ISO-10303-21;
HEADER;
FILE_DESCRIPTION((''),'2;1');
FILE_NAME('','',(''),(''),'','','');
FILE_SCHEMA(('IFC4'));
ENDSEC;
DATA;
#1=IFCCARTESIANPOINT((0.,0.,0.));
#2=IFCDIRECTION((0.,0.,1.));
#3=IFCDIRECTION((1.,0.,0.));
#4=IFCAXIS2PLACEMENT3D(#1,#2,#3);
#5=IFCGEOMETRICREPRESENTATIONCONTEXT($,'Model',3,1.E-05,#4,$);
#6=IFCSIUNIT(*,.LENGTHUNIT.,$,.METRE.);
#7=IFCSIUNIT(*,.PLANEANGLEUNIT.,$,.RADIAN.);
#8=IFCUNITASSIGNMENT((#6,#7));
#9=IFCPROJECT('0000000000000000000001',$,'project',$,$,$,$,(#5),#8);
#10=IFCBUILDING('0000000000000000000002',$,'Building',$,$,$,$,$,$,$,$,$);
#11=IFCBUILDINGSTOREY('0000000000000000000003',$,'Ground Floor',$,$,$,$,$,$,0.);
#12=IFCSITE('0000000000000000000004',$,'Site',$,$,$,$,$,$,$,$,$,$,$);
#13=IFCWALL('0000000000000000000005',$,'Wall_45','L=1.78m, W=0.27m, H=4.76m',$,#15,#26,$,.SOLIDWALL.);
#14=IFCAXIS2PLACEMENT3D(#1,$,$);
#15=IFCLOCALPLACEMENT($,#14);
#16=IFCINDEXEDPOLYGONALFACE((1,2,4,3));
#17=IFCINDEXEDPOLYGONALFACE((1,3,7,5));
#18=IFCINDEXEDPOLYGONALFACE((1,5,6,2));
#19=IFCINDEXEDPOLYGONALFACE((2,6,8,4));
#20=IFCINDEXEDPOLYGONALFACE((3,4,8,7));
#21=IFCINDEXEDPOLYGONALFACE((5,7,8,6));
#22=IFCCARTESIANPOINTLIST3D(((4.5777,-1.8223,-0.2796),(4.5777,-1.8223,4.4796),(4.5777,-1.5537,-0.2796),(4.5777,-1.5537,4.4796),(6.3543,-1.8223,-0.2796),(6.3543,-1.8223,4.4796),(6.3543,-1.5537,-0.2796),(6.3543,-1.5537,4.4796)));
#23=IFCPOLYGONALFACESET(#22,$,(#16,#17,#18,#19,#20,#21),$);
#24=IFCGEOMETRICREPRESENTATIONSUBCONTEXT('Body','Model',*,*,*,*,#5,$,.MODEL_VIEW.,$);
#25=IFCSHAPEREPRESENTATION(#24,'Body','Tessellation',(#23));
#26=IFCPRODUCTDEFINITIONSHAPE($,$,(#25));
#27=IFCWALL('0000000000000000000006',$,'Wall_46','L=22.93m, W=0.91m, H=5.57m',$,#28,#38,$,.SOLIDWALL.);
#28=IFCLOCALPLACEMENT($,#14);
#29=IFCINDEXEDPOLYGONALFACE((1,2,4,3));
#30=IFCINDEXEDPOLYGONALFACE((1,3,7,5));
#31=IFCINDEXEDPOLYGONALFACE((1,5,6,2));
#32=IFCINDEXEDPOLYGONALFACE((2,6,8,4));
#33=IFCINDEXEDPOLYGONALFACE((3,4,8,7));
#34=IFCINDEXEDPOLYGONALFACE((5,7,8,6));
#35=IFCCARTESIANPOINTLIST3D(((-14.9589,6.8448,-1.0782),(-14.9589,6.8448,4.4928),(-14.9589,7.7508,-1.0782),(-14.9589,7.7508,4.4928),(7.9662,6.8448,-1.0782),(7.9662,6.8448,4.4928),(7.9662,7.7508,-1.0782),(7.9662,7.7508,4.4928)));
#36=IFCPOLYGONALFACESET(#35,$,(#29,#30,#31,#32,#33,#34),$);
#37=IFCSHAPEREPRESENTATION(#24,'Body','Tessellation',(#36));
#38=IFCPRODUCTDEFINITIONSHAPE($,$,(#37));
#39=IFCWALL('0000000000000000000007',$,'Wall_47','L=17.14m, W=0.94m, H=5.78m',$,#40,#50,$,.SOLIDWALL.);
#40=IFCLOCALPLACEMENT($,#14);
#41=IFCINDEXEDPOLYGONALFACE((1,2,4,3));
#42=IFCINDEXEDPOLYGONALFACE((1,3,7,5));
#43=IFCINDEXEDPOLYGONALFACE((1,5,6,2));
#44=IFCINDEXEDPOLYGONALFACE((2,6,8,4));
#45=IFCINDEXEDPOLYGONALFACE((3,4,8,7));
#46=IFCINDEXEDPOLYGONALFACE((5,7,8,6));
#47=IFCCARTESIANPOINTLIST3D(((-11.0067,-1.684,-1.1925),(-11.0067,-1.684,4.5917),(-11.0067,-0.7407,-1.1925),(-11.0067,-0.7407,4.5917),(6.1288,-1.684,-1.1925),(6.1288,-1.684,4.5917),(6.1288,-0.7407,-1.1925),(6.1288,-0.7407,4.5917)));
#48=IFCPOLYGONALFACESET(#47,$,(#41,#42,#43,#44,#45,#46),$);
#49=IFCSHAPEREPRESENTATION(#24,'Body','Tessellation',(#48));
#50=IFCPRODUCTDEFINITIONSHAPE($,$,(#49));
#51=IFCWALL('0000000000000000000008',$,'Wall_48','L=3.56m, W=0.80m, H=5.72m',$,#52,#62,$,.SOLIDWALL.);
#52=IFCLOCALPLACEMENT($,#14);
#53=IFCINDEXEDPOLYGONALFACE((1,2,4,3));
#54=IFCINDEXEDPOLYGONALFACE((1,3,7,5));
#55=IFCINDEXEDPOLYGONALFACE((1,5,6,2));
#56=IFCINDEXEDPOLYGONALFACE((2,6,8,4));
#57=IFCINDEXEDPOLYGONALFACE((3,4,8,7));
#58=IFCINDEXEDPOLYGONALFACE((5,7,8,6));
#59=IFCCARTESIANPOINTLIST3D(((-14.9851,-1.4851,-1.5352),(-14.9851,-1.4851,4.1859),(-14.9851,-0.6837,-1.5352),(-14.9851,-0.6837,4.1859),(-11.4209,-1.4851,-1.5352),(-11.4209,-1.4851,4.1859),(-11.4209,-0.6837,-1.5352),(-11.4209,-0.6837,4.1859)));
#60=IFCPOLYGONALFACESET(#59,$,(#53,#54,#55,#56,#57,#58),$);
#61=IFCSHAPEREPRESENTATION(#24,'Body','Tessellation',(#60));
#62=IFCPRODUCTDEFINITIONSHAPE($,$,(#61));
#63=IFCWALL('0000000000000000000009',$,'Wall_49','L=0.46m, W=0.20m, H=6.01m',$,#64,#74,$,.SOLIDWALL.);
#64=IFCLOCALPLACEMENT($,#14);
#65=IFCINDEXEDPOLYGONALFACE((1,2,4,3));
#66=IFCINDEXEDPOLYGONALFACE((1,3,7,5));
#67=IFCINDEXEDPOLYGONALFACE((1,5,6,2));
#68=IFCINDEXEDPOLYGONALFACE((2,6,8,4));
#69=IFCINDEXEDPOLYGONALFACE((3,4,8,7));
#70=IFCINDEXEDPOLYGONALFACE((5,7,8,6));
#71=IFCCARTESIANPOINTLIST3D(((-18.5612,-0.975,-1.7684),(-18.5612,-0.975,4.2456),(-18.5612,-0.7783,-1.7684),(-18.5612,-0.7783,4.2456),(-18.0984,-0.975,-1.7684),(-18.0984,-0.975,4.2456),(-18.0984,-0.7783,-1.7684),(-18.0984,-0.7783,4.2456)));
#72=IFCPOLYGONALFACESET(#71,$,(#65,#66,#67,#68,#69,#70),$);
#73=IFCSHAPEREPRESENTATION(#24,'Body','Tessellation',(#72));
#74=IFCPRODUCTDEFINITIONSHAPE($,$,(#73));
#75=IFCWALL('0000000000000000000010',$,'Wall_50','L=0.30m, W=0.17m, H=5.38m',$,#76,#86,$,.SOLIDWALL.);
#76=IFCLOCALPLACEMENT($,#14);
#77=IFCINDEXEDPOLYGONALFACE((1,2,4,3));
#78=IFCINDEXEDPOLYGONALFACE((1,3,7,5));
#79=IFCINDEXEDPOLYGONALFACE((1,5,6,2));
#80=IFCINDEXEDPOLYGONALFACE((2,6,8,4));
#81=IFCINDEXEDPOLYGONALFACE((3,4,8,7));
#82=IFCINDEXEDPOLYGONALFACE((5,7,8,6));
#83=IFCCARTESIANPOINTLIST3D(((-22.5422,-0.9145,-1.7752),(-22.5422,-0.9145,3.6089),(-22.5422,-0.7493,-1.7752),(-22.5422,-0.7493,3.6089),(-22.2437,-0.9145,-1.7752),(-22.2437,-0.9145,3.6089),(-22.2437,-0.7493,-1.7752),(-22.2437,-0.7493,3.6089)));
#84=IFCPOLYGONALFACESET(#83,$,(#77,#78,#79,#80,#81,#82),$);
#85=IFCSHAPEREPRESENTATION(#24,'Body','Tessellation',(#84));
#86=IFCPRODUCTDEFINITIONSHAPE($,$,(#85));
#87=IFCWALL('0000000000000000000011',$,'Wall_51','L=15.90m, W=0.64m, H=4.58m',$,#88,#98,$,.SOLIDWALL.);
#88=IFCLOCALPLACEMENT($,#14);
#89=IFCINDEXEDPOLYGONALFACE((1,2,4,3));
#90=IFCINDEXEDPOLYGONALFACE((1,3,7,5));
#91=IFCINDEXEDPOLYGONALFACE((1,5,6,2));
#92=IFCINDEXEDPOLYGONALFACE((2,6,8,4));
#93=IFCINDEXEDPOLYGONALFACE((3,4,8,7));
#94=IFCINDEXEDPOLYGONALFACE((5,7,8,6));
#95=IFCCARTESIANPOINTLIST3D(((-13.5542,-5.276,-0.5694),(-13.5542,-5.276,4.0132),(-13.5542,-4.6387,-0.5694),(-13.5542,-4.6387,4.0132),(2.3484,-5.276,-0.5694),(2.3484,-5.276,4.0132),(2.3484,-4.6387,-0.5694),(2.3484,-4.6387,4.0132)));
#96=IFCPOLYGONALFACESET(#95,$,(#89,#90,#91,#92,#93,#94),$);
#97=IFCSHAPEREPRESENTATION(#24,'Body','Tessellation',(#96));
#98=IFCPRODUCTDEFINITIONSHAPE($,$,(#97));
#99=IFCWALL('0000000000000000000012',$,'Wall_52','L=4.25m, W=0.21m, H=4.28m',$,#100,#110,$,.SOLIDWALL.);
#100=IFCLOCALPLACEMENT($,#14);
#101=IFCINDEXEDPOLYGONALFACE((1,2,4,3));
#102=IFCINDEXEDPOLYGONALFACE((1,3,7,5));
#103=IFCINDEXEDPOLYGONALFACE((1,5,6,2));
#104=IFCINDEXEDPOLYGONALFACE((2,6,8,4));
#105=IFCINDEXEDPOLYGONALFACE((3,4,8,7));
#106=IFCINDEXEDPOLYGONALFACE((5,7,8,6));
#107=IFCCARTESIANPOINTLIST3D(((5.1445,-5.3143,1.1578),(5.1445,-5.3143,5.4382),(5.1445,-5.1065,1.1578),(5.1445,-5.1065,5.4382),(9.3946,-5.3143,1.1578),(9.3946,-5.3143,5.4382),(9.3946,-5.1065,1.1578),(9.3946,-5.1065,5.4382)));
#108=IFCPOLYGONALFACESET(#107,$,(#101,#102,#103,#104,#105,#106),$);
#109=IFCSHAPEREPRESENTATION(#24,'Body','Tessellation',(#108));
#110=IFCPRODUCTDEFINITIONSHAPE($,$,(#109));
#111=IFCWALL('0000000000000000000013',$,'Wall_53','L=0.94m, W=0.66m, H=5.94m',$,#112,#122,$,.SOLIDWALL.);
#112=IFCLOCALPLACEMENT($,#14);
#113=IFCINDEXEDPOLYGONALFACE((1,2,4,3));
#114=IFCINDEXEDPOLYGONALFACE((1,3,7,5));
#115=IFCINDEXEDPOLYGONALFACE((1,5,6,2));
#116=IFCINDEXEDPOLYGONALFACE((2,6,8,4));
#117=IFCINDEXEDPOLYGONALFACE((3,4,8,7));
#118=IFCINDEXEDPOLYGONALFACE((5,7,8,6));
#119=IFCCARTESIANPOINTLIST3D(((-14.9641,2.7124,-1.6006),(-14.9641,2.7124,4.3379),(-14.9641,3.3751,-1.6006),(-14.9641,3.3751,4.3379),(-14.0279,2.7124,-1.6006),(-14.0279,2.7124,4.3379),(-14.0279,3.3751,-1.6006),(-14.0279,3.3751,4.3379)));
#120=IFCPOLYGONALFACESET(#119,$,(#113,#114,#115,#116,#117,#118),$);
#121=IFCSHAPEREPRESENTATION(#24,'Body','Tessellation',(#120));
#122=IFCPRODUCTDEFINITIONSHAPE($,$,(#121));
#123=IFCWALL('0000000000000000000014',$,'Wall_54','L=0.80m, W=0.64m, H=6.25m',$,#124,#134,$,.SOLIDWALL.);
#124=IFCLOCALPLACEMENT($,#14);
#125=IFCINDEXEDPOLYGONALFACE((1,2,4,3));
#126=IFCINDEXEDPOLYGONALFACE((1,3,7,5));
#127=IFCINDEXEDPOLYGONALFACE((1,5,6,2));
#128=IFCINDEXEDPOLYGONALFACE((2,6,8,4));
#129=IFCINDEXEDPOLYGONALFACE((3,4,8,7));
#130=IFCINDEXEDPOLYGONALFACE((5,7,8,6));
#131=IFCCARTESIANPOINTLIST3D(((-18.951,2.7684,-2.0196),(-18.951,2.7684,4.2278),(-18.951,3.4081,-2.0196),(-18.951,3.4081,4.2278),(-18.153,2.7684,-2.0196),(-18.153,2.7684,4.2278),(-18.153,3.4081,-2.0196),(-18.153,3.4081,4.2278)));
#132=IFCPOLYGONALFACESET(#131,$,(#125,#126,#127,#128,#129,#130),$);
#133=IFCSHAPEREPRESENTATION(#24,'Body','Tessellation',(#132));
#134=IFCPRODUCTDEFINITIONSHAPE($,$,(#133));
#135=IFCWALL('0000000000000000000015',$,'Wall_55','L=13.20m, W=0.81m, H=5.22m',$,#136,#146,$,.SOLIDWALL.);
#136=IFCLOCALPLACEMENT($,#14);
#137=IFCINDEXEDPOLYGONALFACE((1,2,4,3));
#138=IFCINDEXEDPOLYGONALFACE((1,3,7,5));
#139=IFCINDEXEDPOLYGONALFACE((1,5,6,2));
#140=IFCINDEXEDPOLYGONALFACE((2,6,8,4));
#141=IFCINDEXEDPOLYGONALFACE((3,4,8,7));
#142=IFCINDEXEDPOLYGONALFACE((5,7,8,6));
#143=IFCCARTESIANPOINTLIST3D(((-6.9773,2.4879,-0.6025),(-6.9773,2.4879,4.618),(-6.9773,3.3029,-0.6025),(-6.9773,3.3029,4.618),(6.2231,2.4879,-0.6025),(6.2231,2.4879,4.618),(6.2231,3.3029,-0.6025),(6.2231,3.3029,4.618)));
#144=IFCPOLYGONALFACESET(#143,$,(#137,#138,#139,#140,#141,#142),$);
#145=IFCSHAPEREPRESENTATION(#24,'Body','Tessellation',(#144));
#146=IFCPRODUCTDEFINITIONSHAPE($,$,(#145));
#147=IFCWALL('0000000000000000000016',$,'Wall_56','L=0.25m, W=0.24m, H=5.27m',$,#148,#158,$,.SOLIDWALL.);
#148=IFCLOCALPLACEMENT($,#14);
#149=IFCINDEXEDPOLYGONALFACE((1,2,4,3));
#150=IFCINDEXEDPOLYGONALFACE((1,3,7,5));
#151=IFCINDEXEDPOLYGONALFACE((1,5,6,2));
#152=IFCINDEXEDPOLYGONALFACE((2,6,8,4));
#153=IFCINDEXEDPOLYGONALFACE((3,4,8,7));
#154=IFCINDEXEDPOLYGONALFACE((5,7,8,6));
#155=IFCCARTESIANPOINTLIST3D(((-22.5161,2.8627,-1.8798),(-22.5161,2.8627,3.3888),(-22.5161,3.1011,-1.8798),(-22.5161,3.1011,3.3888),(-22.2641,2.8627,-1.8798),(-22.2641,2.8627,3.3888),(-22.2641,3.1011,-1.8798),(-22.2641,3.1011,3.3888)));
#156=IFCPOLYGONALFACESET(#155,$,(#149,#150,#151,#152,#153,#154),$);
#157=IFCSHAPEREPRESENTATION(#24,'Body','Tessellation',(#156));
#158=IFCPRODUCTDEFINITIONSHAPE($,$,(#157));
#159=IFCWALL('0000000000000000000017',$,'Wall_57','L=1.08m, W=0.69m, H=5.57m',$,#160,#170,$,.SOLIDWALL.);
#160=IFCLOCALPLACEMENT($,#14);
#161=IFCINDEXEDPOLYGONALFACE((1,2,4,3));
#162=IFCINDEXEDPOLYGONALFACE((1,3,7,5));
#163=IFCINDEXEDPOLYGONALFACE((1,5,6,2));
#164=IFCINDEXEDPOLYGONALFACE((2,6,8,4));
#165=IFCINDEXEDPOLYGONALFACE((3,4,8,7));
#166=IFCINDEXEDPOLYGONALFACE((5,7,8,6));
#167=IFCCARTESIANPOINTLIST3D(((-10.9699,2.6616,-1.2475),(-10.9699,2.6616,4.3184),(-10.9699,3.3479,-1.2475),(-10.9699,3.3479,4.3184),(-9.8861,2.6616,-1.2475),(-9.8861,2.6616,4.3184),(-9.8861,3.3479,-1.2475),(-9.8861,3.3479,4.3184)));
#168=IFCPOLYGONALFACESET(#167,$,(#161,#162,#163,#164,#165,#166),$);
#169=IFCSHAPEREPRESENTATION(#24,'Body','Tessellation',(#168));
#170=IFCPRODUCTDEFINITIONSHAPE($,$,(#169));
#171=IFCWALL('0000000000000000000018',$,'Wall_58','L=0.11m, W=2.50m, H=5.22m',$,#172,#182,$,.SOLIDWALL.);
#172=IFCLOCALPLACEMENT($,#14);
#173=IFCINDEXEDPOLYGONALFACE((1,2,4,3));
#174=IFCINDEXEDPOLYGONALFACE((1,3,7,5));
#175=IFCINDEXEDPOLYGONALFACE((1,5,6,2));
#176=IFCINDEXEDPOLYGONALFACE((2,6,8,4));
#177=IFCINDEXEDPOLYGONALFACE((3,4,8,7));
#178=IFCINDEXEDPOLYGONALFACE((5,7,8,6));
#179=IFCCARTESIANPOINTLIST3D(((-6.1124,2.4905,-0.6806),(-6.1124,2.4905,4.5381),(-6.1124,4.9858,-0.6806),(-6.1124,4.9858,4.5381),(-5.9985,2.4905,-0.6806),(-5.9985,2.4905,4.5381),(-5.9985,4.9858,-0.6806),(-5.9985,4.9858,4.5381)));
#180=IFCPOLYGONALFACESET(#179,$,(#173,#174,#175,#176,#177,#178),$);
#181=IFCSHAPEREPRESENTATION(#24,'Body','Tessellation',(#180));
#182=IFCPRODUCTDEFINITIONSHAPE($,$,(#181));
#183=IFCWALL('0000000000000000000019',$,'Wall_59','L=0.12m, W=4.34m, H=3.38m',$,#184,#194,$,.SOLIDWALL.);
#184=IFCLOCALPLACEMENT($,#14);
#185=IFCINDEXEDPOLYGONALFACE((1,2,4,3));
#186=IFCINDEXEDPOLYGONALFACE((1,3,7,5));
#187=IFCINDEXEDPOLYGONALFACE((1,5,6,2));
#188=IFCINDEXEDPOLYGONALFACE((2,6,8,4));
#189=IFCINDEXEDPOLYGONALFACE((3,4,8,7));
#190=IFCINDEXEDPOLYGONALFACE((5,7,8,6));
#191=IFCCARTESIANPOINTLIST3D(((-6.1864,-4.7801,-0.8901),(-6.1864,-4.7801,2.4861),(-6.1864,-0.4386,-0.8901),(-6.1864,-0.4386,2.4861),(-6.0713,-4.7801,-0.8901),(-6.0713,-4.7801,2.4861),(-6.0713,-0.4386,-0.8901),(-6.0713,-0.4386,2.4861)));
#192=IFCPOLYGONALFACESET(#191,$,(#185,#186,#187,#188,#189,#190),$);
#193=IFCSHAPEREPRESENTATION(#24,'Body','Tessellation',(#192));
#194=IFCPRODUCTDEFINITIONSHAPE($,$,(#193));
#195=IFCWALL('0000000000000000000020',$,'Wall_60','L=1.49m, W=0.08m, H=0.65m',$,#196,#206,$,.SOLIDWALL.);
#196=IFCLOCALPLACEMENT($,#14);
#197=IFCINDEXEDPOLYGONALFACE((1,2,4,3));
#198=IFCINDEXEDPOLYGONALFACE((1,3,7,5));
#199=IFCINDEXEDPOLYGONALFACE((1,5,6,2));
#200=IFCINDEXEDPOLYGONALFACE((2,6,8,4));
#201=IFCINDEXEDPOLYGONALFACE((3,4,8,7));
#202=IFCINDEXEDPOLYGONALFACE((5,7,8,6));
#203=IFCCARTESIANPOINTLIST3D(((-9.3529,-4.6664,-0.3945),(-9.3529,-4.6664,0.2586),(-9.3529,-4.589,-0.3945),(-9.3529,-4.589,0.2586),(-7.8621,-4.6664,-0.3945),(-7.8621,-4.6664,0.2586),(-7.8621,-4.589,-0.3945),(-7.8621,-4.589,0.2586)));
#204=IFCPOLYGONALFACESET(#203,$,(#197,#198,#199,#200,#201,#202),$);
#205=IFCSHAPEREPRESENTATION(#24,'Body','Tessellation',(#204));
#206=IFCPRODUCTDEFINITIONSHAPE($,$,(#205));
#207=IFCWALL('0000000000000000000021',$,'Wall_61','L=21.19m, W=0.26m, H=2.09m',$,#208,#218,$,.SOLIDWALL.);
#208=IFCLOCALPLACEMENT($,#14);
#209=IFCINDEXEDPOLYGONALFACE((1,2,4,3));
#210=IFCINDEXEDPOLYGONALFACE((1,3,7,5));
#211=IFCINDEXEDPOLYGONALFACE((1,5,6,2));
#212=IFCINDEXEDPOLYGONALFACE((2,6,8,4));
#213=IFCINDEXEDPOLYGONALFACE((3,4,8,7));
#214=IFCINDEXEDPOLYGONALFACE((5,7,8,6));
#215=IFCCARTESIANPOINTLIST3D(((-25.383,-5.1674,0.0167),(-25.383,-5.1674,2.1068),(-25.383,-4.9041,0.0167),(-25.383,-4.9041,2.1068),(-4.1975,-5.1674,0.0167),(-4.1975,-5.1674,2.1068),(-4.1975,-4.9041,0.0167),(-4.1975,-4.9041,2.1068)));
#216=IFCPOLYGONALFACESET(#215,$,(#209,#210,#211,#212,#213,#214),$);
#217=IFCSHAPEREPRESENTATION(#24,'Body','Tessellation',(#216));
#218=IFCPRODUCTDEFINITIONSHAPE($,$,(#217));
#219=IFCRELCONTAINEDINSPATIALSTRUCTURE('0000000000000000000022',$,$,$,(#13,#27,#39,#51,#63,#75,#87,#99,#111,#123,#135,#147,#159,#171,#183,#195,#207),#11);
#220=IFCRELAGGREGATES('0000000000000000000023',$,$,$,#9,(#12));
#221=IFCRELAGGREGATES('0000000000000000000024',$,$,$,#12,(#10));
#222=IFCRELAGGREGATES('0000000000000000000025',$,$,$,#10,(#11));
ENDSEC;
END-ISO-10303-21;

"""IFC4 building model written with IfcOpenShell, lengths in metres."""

from ifc_helpers import new_model, si_unit, frame, origin_with_axes, origin_2d, context, subcontext, project, spatial, rectangle, extrude, element, save


model = new_model("IFC4")

# Units and contexts
model_context = context("Model", 3, precision=1e-05, world=origin_with_axes())
body_context = subcontext(model_context, "Body", "Model", "MODEL_VIEW")
ifc_project = project(units=[si_unit("LENGTHUNIT", "METRE"), si_unit("PLANEANGLEUNIT", "RADIAN")], contexts=[model_context])

# Site, building, storey
site = spatial("IfcSite", under=ifc_project, Name="Site")
building = spatial("IfcBuilding", under=site, Name="Building")
storey = spatial("IfcBuildingStorey", under=building, Name="Ground Floor", Elevation=0.0)

# Walls
element("IfcWall", 1, inside=storey, Name="Wall_45", Description="L=1.78m, W=0.27m, H=4.76m", PredefinedType="SOLIDWALL", context=body_context, shape_type="SweptSolid", body=[
    extrude(rectangle(XDim=1.7765, YDim=0.2686, at=origin_2d()), frame((5.466, -1.688, -0.2796), z_axis=(0.0, 0.0, 1.0), x_axis=(1.0, 0.0, 0.0)), (0.0, 0.0, 1.0), 4.7592),
])
element("IfcWall", 2, inside=storey, Name="Wall_46", Description="L=22.93m, W=0.91m, H=5.57m", PredefinedType="SOLIDWALL", context=body_context, shape_type="SweptSolid", body=[
    extrude(rectangle(XDim=22.9251, YDim=0.906, at=origin_2d()), frame((-3.4964, 7.2978, -1.0782), z_axis=(0.0, 0.0, 1.0), x_axis=(1.0, 0.0, 0.0)), (0.0, 0.0, 1.0), 5.571),
])
element("IfcWall", 3, inside=storey, Name="Wall_47", Description="L=17.14m, W=0.94m, H=5.78m", PredefinedType="SOLIDWALL", context=body_context, shape_type="SweptSolid", body=[
    extrude(rectangle(XDim=17.1355, YDim=0.9433, at=origin_2d()), frame((-2.4389, -1.2124, -1.1925), z_axis=(0.0, 0.0, 1.0), x_axis=(1.0, 0.0, 0.0)), (0.0, 0.0, 1.0), 5.7842),
])
element("IfcWall", 4, inside=storey, Name="Wall_48", Description="L=3.56m, W=0.80m, H=5.72m", PredefinedType="SOLIDWALL", context=body_context, shape_type="SweptSolid", body=[
    extrude(rectangle(XDim=3.5642, YDim=0.8014, at=origin_2d()), frame((-13.203, -1.0844, -1.5352), z_axis=(0.0, 0.0, 1.0), x_axis=(1.0, 0.0, 0.0)), (0.0, 0.0, 1.0), 5.7211),
])
element("IfcWall", 5, inside=storey, Name="Wall_49", Description="L=0.46m, W=0.20m, H=6.01m", PredefinedType="SOLIDWALL", context=body_context, shape_type="SweptSolid", body=[
    extrude(rectangle(XDim=0.4628, YDim=0.1967, at=origin_2d()), frame((-18.3298, -0.8766, -1.7684), z_axis=(0.0, 0.0, 1.0), x_axis=(1.0, 0.0, 0.0)), (0.0, 0.0, 1.0), 6.014),
])
element("IfcWall", 6, inside=storey, Name="Wall_50", Description="L=0.30m, W=0.17m, H=5.38m", PredefinedType="SOLIDWALL", context=body_context, shape_type="SweptSolid", body=[
    extrude(rectangle(XDim=0.2985, YDim=0.1652, at=origin_2d()), frame((-22.3929, -0.8319, -1.7752), z_axis=(0.0, 0.0, 1.0), x_axis=(1.0, 0.0, 0.0)), (0.0, 0.0, 1.0), 5.3841),
])
element("IfcWall", 7, inside=storey, Name="Wall_51", Description="L=15.90m, W=0.64m, H=4.58m", PredefinedType="SOLIDWALL", context=body_context, shape_type="SweptSolid", body=[
    extrude(rectangle(XDim=15.9026, YDim=0.6373, at=origin_2d()), frame((-5.6029, -4.9573, -0.5694), z_axis=(0.0, 0.0, 1.0), x_axis=(1.0, 0.0, 0.0)), (0.0, 0.0, 1.0), 4.5827),
])
element("IfcWall", 8, inside=storey, Name="Wall_52", Description="L=4.25m, W=0.21m, H=4.28m", PredefinedType="SOLIDWALL", context=body_context, shape_type="SweptSolid", body=[
    extrude(rectangle(XDim=4.2501, YDim=0.2079, at=origin_2d()), frame((7.2695, -5.2104, 1.1578), z_axis=(0.0, 0.0, 1.0), x_axis=(1.0, 0.0, 0.0)), (0.0, 0.0, 1.0), 4.2804),
])
element("IfcWall", 9, inside=storey, Name="Wall_53", Description="L=0.94m, W=0.66m, H=5.94m", PredefinedType="SOLIDWALL", context=body_context, shape_type="SweptSolid", body=[
    extrude(rectangle(XDim=0.9362, YDim=0.6626, at=origin_2d()), frame((-14.496, 3.0438, -1.6006), z_axis=(0.0, 0.0, 1.0), x_axis=(1.0, 0.0, 0.0)), (0.0, 0.0, 1.0), 5.9385),
])
element("IfcWall", 10, inside=storey, Name="Wall_54", Description="L=0.80m, W=0.64m, H=6.25m", PredefinedType="SOLIDWALL", context=body_context, shape_type="SweptSolid", body=[
    extrude(rectangle(XDim=0.7979, YDim=0.6396, at=origin_2d()), frame((-18.552, 3.0883, -2.0196), z_axis=(0.0, 0.0, 1.0), x_axis=(1.0, 0.0, 0.0)), (0.0, 0.0, 1.0), 6.2474),
])
element("IfcWall", 11, inside=storey, Name="Wall_55", Description="L=13.20m, W=0.81m, H=5.22m", PredefinedType="SOLIDWALL", context=body_context, shape_type="SweptSolid", body=[
    extrude(rectangle(XDim=13.2003, YDim=0.815, at=origin_2d()), frame((-0.3771, 2.8954, -0.6025), z_axis=(0.0, 0.0, 1.0), x_axis=(1.0, 0.0, 0.0)), (0.0, 0.0, 1.0), 5.2206),
])
element("IfcWall", 12, inside=storey, Name="Wall_56", Description="L=0.25m, W=0.24m, H=5.27m", PredefinedType="SOLIDWALL", context=body_context, shape_type="SweptSolid", body=[
    extrude(rectangle(XDim=0.252, YDim=0.2384, at=origin_2d()), frame((-22.3901, 2.9819, -1.8798), z_axis=(0.0, 0.0, 1.0), x_axis=(1.0, 0.0, 0.0)), (0.0, 0.0, 1.0), 5.2687),
])
element("IfcWall", 13, inside=storey, Name="Wall_57", Description="L=1.08m, W=0.69m, H=5.57m", PredefinedType="SOLIDWALL", context=body_context, shape_type="SweptSolid", body=[
    extrude(rectangle(XDim=1.0838, YDim=0.6863, at=origin_2d()), frame((-10.428, 3.0048, -1.2475), z_axis=(0.0, 0.0, 1.0), x_axis=(1.0, 0.0, 0.0)), (0.0, 0.0, 1.0), 5.5659),
])
element("IfcWall", 14, inside=storey, Name="Wall_58", Description="L=0.11m, W=2.50m, H=5.22m", PredefinedType="SOLIDWALL", context=body_context, shape_type="SweptSolid", body=[
    extrude(rectangle(XDim=0.114, YDim=2.4953, at=origin_2d()), frame((-6.0555, 3.7382, -0.6806), z_axis=(0.0, 0.0, 1.0), x_axis=(1.0, 0.0, 0.0)), (0.0, 0.0, 1.0), 5.2186),
])
element("IfcWall", 15, inside=storey, Name="Wall_59", Description="L=0.12m, W=4.34m, H=3.38m", PredefinedType="SOLIDWALL", context=body_context, shape_type="SweptSolid", body=[
    extrude(rectangle(XDim=0.1151, YDim=4.3415, at=origin_2d()), frame((-6.1289, -2.6094, -0.8901), z_axis=(0.0, 0.0, 1.0), x_axis=(1.0, 0.0, 0.0)), (0.0, 0.0, 1.0), 3.3762),
])
element("IfcWall", 16, inside=storey, Name="Wall_60", Description="L=1.49m, W=0.08m, H=0.65m", PredefinedType="SOLIDWALL", context=body_context, shape_type="SweptSolid", body=[
    extrude(rectangle(XDim=1.4908, YDim=0.0774, at=origin_2d()), frame((-8.6075, -4.6277, -0.3945), z_axis=(0.0, 0.0, 1.0), x_axis=(1.0, 0.0, 0.0)), (0.0, 0.0, 1.0), 0.6531),
])
element("IfcWall", 17, inside=storey, Name="Wall_61", Description="L=21.19m, W=0.26m, H=2.09m", PredefinedType="SOLIDWALL", context=body_context, shape_type="SweptSolid", body=[
    extrude(rectangle(XDim=21.1854, YDim=0.2632, at=origin_2d()), frame((-14.7902, -5.0357, 0.0167), z_axis=(0.0, 0.0, 1.0), x_axis=(1.0, 0.0, 0.0)), (0.0, 0.0, 1.0), 2.0901),
])

save(model, "model.ifc")
